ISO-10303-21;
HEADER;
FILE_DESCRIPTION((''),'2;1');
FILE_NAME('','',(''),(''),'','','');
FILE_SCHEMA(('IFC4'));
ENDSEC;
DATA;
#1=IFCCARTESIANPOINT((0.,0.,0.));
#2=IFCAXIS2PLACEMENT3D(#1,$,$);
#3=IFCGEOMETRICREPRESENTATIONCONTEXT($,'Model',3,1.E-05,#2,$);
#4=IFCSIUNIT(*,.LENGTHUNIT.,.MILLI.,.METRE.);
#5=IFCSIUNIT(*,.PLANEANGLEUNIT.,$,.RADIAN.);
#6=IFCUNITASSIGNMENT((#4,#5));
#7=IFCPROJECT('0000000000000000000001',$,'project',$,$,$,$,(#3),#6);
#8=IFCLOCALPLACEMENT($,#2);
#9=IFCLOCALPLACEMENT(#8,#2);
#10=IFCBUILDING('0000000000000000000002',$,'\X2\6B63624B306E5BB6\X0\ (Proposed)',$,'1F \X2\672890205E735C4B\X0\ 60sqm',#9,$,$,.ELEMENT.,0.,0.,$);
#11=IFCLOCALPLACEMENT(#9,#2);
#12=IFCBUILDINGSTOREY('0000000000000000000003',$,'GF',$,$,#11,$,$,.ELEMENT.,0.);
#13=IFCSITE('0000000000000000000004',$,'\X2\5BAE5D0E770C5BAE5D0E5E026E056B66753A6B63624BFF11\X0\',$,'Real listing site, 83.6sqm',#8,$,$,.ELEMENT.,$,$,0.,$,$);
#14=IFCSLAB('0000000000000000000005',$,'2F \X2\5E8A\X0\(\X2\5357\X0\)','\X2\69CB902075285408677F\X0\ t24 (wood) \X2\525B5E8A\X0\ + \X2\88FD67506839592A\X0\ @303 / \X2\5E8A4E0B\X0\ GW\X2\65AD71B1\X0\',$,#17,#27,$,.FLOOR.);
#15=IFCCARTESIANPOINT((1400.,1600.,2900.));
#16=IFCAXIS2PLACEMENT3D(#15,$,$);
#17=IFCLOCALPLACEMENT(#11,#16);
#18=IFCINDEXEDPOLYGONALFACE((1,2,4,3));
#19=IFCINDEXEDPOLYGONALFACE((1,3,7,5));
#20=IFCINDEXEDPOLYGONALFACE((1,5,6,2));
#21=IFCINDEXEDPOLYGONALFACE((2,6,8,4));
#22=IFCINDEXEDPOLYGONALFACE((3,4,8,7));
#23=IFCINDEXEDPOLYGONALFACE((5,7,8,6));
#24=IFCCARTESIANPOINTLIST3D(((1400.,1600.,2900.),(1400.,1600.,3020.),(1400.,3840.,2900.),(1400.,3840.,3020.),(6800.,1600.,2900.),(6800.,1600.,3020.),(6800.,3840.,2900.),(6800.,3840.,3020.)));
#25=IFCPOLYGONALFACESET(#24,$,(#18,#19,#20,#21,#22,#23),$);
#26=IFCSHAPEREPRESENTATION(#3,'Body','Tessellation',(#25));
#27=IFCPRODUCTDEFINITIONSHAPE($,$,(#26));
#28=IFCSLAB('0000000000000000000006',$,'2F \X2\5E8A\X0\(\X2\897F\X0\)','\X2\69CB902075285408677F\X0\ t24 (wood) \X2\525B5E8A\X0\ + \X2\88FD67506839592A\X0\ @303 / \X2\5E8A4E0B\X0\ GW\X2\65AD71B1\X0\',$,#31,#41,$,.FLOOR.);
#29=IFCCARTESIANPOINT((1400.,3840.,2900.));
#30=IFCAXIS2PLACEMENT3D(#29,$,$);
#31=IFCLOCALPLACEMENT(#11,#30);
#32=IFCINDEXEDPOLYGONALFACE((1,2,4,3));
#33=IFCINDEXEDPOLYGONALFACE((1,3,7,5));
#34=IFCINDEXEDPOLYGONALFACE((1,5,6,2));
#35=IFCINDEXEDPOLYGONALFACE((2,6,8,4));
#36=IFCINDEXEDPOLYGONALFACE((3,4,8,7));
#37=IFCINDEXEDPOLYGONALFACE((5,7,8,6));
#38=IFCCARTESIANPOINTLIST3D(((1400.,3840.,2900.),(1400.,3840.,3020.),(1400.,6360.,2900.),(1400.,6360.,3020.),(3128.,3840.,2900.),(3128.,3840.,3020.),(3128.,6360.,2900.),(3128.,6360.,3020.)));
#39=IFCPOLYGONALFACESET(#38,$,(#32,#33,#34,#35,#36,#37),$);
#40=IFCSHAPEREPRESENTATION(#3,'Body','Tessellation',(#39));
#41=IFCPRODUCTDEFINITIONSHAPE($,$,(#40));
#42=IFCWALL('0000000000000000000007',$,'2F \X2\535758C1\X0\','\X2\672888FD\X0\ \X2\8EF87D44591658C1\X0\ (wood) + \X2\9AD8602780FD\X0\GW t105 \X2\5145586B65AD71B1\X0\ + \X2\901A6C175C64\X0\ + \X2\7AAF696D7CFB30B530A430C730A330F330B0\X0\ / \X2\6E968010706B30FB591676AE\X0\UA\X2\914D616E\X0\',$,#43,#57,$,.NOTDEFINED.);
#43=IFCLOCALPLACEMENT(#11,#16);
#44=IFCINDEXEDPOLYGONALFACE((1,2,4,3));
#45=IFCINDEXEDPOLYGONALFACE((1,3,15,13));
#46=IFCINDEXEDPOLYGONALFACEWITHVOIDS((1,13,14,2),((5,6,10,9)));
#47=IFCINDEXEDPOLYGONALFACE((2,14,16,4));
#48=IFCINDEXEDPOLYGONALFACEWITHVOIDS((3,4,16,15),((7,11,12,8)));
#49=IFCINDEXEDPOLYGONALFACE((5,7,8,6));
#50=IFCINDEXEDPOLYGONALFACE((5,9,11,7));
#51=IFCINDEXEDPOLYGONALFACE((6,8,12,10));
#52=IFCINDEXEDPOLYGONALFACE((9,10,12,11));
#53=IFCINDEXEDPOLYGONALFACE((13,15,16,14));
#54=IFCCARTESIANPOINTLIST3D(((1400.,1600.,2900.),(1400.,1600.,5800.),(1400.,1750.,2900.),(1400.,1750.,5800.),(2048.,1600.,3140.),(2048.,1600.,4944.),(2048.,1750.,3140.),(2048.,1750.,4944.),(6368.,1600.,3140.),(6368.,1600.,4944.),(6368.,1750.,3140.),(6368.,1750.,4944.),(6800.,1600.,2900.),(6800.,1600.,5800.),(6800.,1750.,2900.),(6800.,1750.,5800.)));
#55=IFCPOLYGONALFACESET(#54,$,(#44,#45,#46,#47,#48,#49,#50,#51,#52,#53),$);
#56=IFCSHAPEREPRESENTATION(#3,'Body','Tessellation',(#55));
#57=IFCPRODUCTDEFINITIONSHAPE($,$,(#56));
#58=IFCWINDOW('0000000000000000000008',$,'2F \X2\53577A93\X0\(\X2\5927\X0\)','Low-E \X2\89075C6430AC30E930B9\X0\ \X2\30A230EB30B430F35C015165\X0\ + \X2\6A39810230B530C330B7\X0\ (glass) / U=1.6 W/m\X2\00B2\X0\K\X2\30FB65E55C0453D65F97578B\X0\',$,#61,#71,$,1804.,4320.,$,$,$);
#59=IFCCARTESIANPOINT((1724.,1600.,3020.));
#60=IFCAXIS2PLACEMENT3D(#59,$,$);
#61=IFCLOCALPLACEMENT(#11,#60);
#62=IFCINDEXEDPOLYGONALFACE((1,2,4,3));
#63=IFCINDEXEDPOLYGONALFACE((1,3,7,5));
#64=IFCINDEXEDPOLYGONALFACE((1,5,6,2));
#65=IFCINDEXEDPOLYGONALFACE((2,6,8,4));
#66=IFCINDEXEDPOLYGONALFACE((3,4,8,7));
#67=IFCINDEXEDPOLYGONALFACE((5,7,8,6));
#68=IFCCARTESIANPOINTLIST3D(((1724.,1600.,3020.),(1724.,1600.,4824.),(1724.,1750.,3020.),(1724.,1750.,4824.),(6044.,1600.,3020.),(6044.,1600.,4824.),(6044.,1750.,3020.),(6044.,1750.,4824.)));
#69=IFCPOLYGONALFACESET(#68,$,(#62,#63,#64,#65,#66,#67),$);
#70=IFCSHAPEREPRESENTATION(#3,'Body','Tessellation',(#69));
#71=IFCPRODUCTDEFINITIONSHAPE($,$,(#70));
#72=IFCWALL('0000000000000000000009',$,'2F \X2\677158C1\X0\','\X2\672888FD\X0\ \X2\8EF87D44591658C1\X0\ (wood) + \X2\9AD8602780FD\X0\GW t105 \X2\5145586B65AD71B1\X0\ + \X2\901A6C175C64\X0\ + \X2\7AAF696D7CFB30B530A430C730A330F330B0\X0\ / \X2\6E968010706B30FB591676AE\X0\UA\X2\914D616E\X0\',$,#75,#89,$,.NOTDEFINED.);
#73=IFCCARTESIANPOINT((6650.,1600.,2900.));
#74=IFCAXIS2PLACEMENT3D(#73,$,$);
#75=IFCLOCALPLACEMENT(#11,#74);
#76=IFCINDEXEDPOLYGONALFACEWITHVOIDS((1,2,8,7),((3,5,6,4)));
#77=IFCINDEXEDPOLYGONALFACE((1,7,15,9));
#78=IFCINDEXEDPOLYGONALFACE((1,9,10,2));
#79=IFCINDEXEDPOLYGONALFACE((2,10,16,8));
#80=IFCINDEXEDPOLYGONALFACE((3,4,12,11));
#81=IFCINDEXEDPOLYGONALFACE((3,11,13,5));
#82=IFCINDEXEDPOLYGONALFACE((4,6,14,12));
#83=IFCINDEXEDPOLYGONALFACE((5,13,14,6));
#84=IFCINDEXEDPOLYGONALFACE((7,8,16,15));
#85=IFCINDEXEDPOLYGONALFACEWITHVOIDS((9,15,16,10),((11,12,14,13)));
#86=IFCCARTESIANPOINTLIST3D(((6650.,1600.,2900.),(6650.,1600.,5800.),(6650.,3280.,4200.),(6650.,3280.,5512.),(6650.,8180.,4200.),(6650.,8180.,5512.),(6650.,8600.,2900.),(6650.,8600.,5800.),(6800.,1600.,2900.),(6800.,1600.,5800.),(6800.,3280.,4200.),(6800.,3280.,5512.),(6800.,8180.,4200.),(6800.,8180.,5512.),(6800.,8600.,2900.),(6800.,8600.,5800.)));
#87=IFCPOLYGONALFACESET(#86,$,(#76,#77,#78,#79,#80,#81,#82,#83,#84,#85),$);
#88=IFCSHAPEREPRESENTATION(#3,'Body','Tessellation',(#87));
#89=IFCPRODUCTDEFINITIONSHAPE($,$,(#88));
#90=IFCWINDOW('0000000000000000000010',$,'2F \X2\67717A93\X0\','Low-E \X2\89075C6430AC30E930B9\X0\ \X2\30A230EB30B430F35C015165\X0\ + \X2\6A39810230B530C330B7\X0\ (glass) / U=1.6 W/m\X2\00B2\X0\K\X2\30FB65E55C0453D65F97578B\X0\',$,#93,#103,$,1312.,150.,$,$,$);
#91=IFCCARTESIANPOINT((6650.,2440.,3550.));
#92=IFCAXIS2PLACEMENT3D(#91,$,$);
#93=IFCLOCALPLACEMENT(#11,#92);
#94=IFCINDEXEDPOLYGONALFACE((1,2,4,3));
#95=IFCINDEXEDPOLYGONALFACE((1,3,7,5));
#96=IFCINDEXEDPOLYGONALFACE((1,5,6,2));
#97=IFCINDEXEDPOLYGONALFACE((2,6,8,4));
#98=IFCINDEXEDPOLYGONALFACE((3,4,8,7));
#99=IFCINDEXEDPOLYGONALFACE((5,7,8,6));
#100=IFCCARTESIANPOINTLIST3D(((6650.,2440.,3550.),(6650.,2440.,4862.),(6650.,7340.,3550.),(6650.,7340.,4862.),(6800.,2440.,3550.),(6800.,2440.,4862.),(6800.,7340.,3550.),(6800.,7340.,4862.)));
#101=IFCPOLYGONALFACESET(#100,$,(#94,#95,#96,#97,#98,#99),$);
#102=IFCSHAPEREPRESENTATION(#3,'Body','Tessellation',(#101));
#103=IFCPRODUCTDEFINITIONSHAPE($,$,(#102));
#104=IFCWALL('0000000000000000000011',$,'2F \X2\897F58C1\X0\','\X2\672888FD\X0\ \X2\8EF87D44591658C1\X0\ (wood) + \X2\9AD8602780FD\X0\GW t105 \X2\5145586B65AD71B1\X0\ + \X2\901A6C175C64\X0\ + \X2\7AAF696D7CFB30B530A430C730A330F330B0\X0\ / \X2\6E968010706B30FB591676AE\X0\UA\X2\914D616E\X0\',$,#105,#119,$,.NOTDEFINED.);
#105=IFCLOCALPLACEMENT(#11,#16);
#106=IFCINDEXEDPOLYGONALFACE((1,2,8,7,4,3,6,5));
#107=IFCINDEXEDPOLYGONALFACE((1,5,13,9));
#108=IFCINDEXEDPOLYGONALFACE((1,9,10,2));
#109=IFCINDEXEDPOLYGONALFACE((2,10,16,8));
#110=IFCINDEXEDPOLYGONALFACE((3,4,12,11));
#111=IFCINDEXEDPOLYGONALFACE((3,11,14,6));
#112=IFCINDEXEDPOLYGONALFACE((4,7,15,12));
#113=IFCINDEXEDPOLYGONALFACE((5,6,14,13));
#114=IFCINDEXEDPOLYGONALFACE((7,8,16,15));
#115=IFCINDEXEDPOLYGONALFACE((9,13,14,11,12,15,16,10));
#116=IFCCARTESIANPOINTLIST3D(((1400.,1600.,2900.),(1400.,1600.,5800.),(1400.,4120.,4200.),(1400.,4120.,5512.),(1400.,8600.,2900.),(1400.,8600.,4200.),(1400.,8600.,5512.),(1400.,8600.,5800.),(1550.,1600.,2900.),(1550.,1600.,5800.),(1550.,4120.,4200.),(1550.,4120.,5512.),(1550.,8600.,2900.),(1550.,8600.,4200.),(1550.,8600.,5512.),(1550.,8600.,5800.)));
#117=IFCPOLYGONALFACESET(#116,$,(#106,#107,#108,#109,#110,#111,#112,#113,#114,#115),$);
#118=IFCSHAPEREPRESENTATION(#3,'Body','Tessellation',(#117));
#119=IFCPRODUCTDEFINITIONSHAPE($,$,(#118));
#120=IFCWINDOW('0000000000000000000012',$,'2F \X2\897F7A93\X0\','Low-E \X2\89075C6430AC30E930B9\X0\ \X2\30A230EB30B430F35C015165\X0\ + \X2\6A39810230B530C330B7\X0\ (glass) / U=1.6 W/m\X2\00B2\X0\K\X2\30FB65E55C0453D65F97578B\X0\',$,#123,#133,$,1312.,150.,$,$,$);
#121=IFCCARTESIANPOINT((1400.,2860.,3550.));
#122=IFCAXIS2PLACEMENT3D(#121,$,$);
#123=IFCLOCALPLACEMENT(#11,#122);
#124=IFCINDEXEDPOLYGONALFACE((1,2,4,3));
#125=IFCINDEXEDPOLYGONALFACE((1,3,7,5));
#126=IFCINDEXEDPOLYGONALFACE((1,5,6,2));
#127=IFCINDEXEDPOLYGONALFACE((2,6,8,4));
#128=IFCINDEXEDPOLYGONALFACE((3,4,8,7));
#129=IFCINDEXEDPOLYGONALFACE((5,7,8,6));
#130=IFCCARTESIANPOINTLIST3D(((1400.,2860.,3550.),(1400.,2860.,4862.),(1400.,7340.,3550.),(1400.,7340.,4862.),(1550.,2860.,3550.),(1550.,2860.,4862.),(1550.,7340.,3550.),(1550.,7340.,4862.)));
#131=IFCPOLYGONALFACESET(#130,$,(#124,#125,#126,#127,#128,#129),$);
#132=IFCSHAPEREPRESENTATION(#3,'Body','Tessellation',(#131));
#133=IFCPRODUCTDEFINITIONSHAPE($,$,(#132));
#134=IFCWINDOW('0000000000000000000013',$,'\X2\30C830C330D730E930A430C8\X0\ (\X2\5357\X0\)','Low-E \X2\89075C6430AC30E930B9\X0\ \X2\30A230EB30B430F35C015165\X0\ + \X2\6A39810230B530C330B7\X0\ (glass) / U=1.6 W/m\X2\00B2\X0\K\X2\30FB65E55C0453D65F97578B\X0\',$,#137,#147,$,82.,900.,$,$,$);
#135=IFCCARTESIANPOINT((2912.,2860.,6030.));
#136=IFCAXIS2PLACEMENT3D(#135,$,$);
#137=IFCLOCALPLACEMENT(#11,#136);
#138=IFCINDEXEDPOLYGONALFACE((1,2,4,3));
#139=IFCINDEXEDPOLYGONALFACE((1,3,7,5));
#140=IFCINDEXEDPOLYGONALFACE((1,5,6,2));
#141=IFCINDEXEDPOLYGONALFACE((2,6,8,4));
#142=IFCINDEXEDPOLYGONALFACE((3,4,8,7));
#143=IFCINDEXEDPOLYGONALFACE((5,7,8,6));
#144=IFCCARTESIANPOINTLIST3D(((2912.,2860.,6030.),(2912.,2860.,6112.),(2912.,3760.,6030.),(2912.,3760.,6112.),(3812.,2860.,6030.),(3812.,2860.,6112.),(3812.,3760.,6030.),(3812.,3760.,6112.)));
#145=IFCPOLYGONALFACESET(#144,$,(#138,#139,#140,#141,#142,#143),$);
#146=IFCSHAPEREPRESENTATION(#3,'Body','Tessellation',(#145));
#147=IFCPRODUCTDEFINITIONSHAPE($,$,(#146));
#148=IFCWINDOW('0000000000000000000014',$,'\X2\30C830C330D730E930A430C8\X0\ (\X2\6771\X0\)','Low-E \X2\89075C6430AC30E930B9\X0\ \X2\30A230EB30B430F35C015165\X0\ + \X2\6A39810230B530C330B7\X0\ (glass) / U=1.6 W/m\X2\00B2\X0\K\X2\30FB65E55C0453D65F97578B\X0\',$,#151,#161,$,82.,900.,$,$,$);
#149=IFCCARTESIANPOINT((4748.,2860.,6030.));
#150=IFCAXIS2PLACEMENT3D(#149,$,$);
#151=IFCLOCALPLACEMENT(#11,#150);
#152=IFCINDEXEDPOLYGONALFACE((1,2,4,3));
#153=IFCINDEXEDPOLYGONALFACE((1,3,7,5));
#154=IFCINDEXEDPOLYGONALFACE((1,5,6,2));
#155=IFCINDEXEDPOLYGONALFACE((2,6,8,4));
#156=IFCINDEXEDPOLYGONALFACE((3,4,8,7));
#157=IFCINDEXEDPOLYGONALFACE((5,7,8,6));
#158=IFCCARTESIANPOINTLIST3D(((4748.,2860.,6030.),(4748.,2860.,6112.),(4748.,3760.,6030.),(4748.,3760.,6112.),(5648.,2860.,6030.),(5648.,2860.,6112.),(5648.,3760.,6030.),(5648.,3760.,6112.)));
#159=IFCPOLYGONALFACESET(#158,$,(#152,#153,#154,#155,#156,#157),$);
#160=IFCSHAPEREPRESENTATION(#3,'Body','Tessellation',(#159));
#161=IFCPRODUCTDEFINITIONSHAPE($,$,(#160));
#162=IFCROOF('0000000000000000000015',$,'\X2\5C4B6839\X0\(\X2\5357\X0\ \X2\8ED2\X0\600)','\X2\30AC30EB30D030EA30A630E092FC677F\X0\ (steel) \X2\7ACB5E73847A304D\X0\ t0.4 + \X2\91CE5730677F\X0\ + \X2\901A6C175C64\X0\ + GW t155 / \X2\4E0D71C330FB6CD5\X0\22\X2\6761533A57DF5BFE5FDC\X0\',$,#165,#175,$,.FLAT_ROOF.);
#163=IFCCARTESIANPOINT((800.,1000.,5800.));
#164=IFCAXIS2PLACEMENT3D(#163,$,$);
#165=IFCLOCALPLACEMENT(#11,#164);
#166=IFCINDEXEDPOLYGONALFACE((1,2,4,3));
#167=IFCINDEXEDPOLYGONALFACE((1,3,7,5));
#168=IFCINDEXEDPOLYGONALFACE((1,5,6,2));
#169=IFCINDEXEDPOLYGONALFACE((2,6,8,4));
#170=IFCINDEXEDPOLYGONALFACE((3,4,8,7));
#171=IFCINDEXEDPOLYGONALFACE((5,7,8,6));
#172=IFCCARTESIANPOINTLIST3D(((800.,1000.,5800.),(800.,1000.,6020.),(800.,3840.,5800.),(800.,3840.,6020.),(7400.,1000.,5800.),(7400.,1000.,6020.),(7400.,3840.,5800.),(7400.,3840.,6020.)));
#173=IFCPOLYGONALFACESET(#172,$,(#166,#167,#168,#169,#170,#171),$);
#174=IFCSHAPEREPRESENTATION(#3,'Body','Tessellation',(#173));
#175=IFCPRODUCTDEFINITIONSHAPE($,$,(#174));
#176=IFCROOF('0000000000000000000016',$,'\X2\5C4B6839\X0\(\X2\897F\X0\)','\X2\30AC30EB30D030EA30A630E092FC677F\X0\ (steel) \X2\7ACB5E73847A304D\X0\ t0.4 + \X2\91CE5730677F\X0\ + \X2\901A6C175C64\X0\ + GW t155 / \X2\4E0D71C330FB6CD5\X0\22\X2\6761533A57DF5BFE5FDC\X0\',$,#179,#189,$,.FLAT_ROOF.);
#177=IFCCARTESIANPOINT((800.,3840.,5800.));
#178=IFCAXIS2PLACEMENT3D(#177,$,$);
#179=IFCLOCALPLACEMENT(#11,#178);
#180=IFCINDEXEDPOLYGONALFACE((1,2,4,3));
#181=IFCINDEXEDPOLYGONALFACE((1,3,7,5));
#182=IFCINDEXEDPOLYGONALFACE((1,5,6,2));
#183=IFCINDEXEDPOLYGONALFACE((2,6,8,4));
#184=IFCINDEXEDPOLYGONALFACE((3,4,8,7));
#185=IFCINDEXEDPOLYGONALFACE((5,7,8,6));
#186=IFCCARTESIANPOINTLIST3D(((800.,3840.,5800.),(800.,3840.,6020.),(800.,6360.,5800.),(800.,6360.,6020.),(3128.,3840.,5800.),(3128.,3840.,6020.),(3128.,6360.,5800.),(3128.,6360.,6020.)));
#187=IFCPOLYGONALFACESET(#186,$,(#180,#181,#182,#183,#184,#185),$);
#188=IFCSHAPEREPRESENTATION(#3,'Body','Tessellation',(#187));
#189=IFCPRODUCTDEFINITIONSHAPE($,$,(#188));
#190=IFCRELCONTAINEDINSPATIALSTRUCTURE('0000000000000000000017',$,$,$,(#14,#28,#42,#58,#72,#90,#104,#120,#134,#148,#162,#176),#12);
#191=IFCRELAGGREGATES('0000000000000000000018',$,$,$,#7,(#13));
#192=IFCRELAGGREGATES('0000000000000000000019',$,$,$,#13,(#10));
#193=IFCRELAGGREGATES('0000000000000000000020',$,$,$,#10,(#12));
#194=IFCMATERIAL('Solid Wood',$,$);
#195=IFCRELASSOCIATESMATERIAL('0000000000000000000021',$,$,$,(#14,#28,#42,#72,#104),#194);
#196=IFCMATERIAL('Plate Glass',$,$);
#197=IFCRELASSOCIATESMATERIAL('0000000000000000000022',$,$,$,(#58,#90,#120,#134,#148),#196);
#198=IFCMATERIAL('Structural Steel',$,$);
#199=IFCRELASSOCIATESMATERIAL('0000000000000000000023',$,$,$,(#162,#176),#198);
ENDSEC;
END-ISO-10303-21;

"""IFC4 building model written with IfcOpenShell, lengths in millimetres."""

from ifc_helpers import new_model, si_unit, frame, frame_2d, origin, place, context, project, spatial, rectangle, extrude, material, element, fill, save


model = new_model("IFC4")

# Units and contexts
model_context = context("Model", 3, precision=1e-05, world=origin())
ifc_project = project(units=[si_unit("LENGTHUNIT", "METRE", prefix="MILLI"), si_unit("PLANEANGLEUNIT", "RADIAN")], contexts=[model_context])

# Site, building, storey
site_placement = place(None, origin())
site = spatial("IfcSite", under=ifc_project, at=site_placement, Name="宮崎県宮崎市清武町正手１", ObjectType="Real listing site, 83.6sqm", CompositionType="ELEMENT", RefElevation=0.0)
building_placement = place(site_placement, origin())
building = spatial("IfcBuilding", under=site, at=building_placement, Name="正手の家 (Proposed)", ObjectType="1F 木造平屋 60sqm", CompositionType="ELEMENT", ElevationOfRefHeight=0.0, ElevationOfTerrain=0.0)
storey_placement = place(building_placement, origin())
storey = spatial("IfcBuildingStorey", under=building, at=storey_placement, Name="GF", CompositionType="ELEMENT", Elevation=0.0)

# Slabs
ifc_material_1 = material(Name="Solid Wood")
slab_1_placement = place(storey_placement, frame((1400.0, 1600.0, 2900.0)))
element("IfcSlab", 1, at=slab_1_placement, inside=storey, material=ifc_material_1, Name="2F 床(南)", Description="構造用合板 t24 (wood) 剛床 + 製材根太 @303 / 床下 GW断熱", PredefinedType="FLOOR", context=model_context, shape_type="SweptSolid", body=[
    extrude(rectangle(XDim=5400.0, YDim=2240.0, at=frame_2d((2700.0, 1120.0))), frame((1400.0, 1600.0, 2900.0)), (0.0, 0.0, 1.0), 120.0),
])
slab_2_placement = place(storey_placement, frame((1400.0, 3840.0, 2900.0)))
element("IfcSlab", 2, at=slab_2_placement, inside=storey, material=ifc_material_1, Name="2F 床(西)", Description="構造用合板 t24 (wood) 剛床 + 製材根太 @303 / 床下 GW断熱", PredefinedType="FLOOR", context=model_context, shape_type="SweptSolid", body=[
    extrude(rectangle(XDim=1728.0, YDim=2520.0, at=frame_2d((864.0, 1260.0))), frame((1400.0, 3840.0, 2900.0)), (0.0, 0.0, 1.0), 120.0),
])

# Walls, openings, windows
wall_1_placement = place(storey_placement, frame((1400.0, 1600.0, 2900.0)))
wall_1 = element("IfcWall", 3, at=wall_1_placement, inside=storey, material=ifc_material_1, Name="2F 南壁", Description="木製 軸組外壁 (wood) + 高性能GW t105 充填断熱 + 通気層 + 窯業系サイディング / 準耐火・外皮UA配慮", PredefinedType="NOTDEFINED", context=model_context, shape_type="SweptSolid", body=[
    extrude(rectangle(XDim=5400.0, YDim=150.0, at=frame_2d((2700.0, 75.0))), frame((1400.0, 1600.0, 2900.0)), (0.0, 0.0, 1.0), 2900.0),
])
opening_1_placement = place(storey_placement, frame((1724.0, 1600.0, 3020.0)))
opening_1 = element("IfcOpeningElement", 4, at=opening_1_placement, cuts=wall_1, PredefinedType="NOTDEFINED", context=model_context, shape_type="SweptSolid", body=[
    extrude(rectangle(XDim=4320.0, YDim=150.0, at=frame_2d((2160.0, 75.0))), frame((1724.0, 1600.0, 3020.0)), (0.0, 0.0, 1.0), 1804.0),
])
ifc_material_2 = material(Name="Plate Glass")
window_1_placement = place(storey_placement, frame((1724.0, 1600.0, 3020.0)))
window_1 = element("IfcWindow", 5, at=window_1_placement, inside=storey, material=ifc_material_2, Name="2F 南窓(大)", Description="Low-E 複層ガラス アルゴン封入 + 樹脂サッシ (glass) / U=1.6 W/m²K・日射取得型", OverallHeight=1804.0, OverallWidth=4320.0, context=model_context, shape_type="SweptSolid", body=[
    extrude(rectangle(XDim=4320.0, YDim=150.0, at=frame_2d((2160.0, 75.0))), frame((1724.0, 1600.0, 3020.0)), (0.0, 0.0, 1.0), 1804.0),
])
fill(opening_1, window_1)
wall_2_placement = place(storey_placement, frame((6650.0, 1600.0, 2900.0)))
wall_2 = element("IfcWall", 6, at=wall_2_placement, inside=storey, material=ifc_material_1, Name="2F 東壁", Description="木製 軸組外壁 (wood) + 高性能GW t105 充填断熱 + 通気層 + 窯業系サイディング / 準耐火・外皮UA配慮", PredefinedType="NOTDEFINED", context=model_context, shape_type="SweptSolid", body=[
    extrude(rectangle(XDim=150.0, YDim=7000.0, at=frame_2d((75.0, 3500.0))), frame((6650.0, 1600.0, 2900.0)), (0.0, 0.0, 1.0), 2900.0),
])
opening_2_placement = place(storey_placement, frame((6650.0, 2440.0, 3550.0)))
opening_2 = element("IfcOpeningElement", 7, at=opening_2_placement, cuts=wall_2, PredefinedType="NOTDEFINED", context=model_context, shape_type="SweptSolid", body=[
    extrude(rectangle(XDim=150.0, YDim=4900.0, at=frame_2d((75.0, 2450.0))), frame((6650.0, 2440.0, 3550.0)), (0.0, 0.0, 1.0), 1312.0),
])
window_2_placement = place(storey_placement, frame((6650.0, 2440.0, 3550.0)))
window_2 = element("IfcWindow", 8, at=window_2_placement, inside=storey, material=ifc_material_2, Name="2F 東窓", Description="Low-E 複層ガラス アルゴン封入 + 樹脂サッシ (glass) / U=1.6 W/m²K・日射取得型", OverallHeight=1312.0, OverallWidth=150.0, context=model_context, shape_type="SweptSolid", body=[
    extrude(rectangle(XDim=150.0, YDim=4900.0, at=frame_2d((75.0, 2450.0))), frame((6650.0, 2440.0, 3550.0)), (0.0, 0.0, 1.0), 1312.0),
])
fill(opening_2, window_2)
wall_3_placement = place(storey_placement, frame((1400.0, 1600.0, 2900.0)))
wall_3 = element("IfcWall", 9, at=wall_3_placement, inside=storey, material=ifc_material_1, Name="2F 西壁", Description="木製 軸組外壁 (wood) + 高性能GW t105 充填断熱 + 通気層 + 窯業系サイディング / 準耐火・外皮UA配慮", PredefinedType="NOTDEFINED", context=model_context, shape_type="SweptSolid", body=[
    extrude(rectangle(XDim=150.0, YDim=7000.0, at=frame_2d((75.0, 3500.0))), frame((1400.0, 1600.0, 2900.0)), (0.0, 0.0, 1.0), 2900.0),
])
opening_3_placement = place(storey_placement, frame((1400.0, 2860.0, 3550.0)))
opening_3 = element("IfcOpeningElement", 10, at=opening_3_placement, cuts=wall_3, PredefinedType="NOTDEFINED", context=model_context, shape_type="SweptSolid", body=[
    extrude(rectangle(XDim=150.0, YDim=4480.0, at=frame_2d((75.0, 2240.0))), frame((1400.0, 2860.0, 3550.0)), (0.0, 0.0, 1.0), 1312.0),
])
window_3_placement = place(storey_placement, frame((1400.0, 2860.0, 3550.0)))
window_3 = element("IfcWindow", 11, at=window_3_placement, inside=storey, material=ifc_material_2, Name="2F 西窓", Description="Low-E 複層ガラス アルゴン封入 + 樹脂サッシ (glass) / U=1.6 W/m²K・日射取得型", OverallHeight=1312.0, OverallWidth=150.0, context=model_context, shape_type="SweptSolid", body=[
    extrude(rectangle(XDim=150.0, YDim=4480.0, at=frame_2d((75.0, 2240.0))), frame((1400.0, 2860.0, 3550.0)), (0.0, 0.0, 1.0), 1312.0),
])
fill(opening_3, window_3)

# Windows
window_4_placement = place(storey_placement, frame((2912.0, 2860.0, 6030.0)))
element("IfcWindow", 12, at=window_4_placement, inside=storey, material=ifc_material_2, Name="トップライト (南)", Description="Low-E 複層ガラス アルゴン封入 + 樹脂サッシ (glass) / U=1.6 W/m²K・日射取得型", OverallHeight=82.0, OverallWidth=900.0, context=model_context, shape_type="SweptSolid", body=[
    extrude(rectangle(XDim=900.0, YDim=900.0, at=frame_2d((450.0, 450.0))), frame((2912.0, 2860.0, 6030.0)), (0.0, 0.0, 1.0), 82.0),
])
window_5_placement = place(storey_placement, frame((4748.0, 2860.0, 6030.0)))
element("IfcWindow", 13, at=window_5_placement, inside=storey, material=ifc_material_2, Name="トップライト (東)", Description="Low-E 複層ガラス アルゴン封入 + 樹脂サッシ (glass) / U=1.6 W/m²K・日射取得型", OverallHeight=82.0, OverallWidth=900.0, context=model_context, shape_type="SweptSolid", body=[
    extrude(rectangle(XDim=900.0, YDim=900.0, at=frame_2d((450.0, 450.0))), frame((4748.0, 2860.0, 6030.0)), (0.0, 0.0, 1.0), 82.0),
])

# Roofs
ifc_material_3 = material(Name="Structural Steel")
roof_1_placement = place(storey_placement, frame((800.0, 1000.0, 5800.0)))
element("IfcRoof", 14, at=roof_1_placement, inside=storey, material=ifc_material_3, Name="屋根(南 軒600)", Description="ガルバリウム鋼板 (steel) 立平葺き t0.4 + 野地板 + 通気層 + GW t155 / 不燃・法22条区域対応", PredefinedType="FLAT_ROOF", context=model_context, shape_type="SweptSolid", body=[
    extrude(rectangle(XDim=6600.0, YDim=2840.0, at=frame_2d((3300.0, 1420.0))), frame((800.0, 1000.0, 5800.0)), (0.0, 0.0, 1.0), 220.0),
])
roof_2_placement = place(storey_placement, frame((800.0, 3840.0, 5800.0)))
element("IfcRoof", 15, at=roof_2_placement, inside=storey, material=ifc_material_3, Name="屋根(西)", Description="ガルバリウム鋼板 (steel) 立平葺き t0.4 + 野地板 + 通気層 + GW t155 / 不燃・法22条区域対応", PredefinedType="FLAT_ROOF", context=model_context, shape_type="SweptSolid", body=[
    extrude(rectangle(XDim=2328.0, YDim=2520.0, at=frame_2d((1164.0, 1260.0))), frame((800.0, 3840.0, 5800.0)), (0.0, 0.0, 1.0), 220.0),
])

save(model, "model.ifc")
